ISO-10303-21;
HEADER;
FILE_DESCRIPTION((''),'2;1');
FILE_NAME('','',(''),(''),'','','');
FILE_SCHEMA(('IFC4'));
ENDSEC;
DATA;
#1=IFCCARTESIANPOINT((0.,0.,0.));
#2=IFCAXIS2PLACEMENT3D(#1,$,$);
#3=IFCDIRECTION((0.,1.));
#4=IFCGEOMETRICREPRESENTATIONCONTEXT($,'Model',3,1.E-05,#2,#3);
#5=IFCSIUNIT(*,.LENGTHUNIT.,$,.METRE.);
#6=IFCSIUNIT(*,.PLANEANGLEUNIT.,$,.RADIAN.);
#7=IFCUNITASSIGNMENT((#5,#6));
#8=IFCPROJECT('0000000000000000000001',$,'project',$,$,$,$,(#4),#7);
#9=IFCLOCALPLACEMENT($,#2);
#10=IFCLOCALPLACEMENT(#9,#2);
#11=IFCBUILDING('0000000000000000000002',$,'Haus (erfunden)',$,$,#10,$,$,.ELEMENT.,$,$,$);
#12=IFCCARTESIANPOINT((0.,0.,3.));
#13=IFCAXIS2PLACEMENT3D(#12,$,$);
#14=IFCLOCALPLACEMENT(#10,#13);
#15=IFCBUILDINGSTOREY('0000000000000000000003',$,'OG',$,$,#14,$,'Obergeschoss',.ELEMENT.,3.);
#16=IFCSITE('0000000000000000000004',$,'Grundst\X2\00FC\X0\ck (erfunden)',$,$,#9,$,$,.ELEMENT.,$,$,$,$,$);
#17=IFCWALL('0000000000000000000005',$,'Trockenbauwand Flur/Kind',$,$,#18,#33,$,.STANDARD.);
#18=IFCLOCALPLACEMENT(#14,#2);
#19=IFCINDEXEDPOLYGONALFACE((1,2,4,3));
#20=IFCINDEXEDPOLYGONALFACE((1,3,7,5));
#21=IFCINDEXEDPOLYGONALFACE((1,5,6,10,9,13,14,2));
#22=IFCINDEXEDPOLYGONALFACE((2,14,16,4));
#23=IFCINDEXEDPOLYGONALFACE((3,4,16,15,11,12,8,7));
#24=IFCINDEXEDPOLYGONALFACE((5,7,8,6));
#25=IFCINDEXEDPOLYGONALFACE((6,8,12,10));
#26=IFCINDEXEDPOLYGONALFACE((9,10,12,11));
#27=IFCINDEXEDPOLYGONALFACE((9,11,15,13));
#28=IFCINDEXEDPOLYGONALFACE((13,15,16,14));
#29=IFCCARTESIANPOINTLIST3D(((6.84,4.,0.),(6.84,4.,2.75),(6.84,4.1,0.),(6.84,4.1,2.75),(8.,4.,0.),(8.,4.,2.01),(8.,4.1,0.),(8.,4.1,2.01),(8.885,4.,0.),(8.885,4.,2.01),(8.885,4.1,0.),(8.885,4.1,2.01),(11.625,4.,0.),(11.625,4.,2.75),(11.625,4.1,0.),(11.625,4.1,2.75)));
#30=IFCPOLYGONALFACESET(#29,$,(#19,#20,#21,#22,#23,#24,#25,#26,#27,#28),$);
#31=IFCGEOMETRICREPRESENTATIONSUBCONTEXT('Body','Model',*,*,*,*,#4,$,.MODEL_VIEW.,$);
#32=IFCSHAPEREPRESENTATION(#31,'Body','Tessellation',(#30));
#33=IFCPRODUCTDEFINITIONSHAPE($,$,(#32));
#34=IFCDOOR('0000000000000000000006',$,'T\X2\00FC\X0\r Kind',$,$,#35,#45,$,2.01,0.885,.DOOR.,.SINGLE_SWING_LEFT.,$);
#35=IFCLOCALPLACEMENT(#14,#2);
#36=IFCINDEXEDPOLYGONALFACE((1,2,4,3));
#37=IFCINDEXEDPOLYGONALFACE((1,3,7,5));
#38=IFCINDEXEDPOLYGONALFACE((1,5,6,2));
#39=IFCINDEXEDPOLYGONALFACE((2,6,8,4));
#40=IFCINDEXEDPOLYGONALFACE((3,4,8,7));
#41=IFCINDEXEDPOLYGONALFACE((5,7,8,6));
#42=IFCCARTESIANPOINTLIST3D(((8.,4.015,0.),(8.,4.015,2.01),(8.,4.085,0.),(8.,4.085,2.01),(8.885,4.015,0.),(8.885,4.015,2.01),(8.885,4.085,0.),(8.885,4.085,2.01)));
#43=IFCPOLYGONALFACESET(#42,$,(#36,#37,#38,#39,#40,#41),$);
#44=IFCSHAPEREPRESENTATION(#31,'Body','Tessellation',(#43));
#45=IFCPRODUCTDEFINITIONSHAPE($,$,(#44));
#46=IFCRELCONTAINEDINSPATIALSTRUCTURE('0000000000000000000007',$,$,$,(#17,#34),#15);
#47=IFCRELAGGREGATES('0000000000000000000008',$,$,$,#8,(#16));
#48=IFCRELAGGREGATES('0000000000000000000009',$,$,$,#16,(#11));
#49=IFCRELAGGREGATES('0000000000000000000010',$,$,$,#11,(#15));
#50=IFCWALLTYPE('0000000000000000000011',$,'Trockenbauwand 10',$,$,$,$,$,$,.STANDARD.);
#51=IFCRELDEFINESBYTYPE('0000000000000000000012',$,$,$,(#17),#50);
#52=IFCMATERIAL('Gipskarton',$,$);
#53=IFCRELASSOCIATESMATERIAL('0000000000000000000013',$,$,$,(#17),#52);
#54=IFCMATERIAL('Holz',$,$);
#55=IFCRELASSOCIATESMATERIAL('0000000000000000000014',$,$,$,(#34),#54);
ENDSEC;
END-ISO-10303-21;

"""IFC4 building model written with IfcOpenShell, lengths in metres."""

from ifc_helpers import new_model, si_unit, direction, frame, frame_2d, origin, place, context, subcontext, project, spatial, rectangle, extrude, material, type_object, element, fill, save


model = new_model("IFC4")

# Units and contexts
model_context = context("Model", 3, precision=1e-05, world=origin(), true_north=direction((0.0, 1.0)))
body_context = subcontext(model_context, "Body", "Model", "MODEL_VIEW")
ifc_project = project(units=[si_unit("LENGTHUNIT", "METRE"), si_unit("PLANEANGLEUNIT", "RADIAN")], contexts=[model_context])

# Site, building, storey
site_placement = place(None, origin())
site = spatial("IfcSite", under=ifc_project, at=site_placement, Name="Grundstück (erfunden)", CompositionType="ELEMENT")
building_placement = place(site_placement, origin())
building = spatial("IfcBuilding", under=site, at=building_placement, Name="Haus (erfunden)", CompositionType="ELEMENT")
storey_placement = place(building_placement, frame((0.0, 0.0, 3.0)))
storey = spatial("IfcBuildingStorey", under=building, at=storey_placement, Name="OG", LongName="Obergeschoss", CompositionType="ELEMENT", Elevation=3.0)

# Wall, opening, door
ifc_material_1 = material(Name="Gipskarton")
wall_type_1 = type_object("IfcWallType", Name="Trockenbauwand 10", PredefinedType="STANDARD")
ifc_material_2 = material(Name="Holz")
wall_1_placement = place(storey_placement, frame((6.84, 4.0, 0.0)))
wall_1 = element("IfcWall", 1, at=wall_1_placement, inside=storey, type_object=wall_type_1, material=ifc_material_1, Name="Trockenbauwand Flur/Kind", PredefinedType="STANDARD", context=body_context, shape_type="SweptSolid", body=[
    extrude(rectangle(XDim=4.785, YDim=0.1, at=frame_2d((2.3925, 0.05))), origin(), (0.0, 0.0, 1.0), 2.75),
])
opening_1_placement = place(wall_1_placement, frame((1.16, -0.05, 0.0)))
opening_1 = element("IfcOpeningElement", 2, at=opening_1_placement, cuts=wall_1, PredefinedType="OPENING", context=body_context, shape_type="SweptSolid", body=[
    extrude(rectangle(XDim=0.885, YDim=0.2, at=frame_2d((0.4425, 0.1))), origin(), (0.0, 0.0, 1.0), 2.01),
])
door_1_placement = place(opening_1_placement, frame((0.0, 0.065, 0.0)))
door_1 = element("IfcDoor", 3, at=door_1_placement, inside=storey, material=ifc_material_2, Name="Tür Kind", OperationType="SINGLE_SWING_LEFT", OverallHeight=2.01, OverallWidth=0.885, PredefinedType="DOOR", context=body_context, shape_type="SweptSolid", body=[
    extrude(rectangle(XDim=0.885, YDim=0.07, at=frame_2d((0.4425, 0.035))), origin(), (0.0, 0.0, 1.0), 2.01),
])
fill(opening_1, door_1)

save(model, "model.ifc")
